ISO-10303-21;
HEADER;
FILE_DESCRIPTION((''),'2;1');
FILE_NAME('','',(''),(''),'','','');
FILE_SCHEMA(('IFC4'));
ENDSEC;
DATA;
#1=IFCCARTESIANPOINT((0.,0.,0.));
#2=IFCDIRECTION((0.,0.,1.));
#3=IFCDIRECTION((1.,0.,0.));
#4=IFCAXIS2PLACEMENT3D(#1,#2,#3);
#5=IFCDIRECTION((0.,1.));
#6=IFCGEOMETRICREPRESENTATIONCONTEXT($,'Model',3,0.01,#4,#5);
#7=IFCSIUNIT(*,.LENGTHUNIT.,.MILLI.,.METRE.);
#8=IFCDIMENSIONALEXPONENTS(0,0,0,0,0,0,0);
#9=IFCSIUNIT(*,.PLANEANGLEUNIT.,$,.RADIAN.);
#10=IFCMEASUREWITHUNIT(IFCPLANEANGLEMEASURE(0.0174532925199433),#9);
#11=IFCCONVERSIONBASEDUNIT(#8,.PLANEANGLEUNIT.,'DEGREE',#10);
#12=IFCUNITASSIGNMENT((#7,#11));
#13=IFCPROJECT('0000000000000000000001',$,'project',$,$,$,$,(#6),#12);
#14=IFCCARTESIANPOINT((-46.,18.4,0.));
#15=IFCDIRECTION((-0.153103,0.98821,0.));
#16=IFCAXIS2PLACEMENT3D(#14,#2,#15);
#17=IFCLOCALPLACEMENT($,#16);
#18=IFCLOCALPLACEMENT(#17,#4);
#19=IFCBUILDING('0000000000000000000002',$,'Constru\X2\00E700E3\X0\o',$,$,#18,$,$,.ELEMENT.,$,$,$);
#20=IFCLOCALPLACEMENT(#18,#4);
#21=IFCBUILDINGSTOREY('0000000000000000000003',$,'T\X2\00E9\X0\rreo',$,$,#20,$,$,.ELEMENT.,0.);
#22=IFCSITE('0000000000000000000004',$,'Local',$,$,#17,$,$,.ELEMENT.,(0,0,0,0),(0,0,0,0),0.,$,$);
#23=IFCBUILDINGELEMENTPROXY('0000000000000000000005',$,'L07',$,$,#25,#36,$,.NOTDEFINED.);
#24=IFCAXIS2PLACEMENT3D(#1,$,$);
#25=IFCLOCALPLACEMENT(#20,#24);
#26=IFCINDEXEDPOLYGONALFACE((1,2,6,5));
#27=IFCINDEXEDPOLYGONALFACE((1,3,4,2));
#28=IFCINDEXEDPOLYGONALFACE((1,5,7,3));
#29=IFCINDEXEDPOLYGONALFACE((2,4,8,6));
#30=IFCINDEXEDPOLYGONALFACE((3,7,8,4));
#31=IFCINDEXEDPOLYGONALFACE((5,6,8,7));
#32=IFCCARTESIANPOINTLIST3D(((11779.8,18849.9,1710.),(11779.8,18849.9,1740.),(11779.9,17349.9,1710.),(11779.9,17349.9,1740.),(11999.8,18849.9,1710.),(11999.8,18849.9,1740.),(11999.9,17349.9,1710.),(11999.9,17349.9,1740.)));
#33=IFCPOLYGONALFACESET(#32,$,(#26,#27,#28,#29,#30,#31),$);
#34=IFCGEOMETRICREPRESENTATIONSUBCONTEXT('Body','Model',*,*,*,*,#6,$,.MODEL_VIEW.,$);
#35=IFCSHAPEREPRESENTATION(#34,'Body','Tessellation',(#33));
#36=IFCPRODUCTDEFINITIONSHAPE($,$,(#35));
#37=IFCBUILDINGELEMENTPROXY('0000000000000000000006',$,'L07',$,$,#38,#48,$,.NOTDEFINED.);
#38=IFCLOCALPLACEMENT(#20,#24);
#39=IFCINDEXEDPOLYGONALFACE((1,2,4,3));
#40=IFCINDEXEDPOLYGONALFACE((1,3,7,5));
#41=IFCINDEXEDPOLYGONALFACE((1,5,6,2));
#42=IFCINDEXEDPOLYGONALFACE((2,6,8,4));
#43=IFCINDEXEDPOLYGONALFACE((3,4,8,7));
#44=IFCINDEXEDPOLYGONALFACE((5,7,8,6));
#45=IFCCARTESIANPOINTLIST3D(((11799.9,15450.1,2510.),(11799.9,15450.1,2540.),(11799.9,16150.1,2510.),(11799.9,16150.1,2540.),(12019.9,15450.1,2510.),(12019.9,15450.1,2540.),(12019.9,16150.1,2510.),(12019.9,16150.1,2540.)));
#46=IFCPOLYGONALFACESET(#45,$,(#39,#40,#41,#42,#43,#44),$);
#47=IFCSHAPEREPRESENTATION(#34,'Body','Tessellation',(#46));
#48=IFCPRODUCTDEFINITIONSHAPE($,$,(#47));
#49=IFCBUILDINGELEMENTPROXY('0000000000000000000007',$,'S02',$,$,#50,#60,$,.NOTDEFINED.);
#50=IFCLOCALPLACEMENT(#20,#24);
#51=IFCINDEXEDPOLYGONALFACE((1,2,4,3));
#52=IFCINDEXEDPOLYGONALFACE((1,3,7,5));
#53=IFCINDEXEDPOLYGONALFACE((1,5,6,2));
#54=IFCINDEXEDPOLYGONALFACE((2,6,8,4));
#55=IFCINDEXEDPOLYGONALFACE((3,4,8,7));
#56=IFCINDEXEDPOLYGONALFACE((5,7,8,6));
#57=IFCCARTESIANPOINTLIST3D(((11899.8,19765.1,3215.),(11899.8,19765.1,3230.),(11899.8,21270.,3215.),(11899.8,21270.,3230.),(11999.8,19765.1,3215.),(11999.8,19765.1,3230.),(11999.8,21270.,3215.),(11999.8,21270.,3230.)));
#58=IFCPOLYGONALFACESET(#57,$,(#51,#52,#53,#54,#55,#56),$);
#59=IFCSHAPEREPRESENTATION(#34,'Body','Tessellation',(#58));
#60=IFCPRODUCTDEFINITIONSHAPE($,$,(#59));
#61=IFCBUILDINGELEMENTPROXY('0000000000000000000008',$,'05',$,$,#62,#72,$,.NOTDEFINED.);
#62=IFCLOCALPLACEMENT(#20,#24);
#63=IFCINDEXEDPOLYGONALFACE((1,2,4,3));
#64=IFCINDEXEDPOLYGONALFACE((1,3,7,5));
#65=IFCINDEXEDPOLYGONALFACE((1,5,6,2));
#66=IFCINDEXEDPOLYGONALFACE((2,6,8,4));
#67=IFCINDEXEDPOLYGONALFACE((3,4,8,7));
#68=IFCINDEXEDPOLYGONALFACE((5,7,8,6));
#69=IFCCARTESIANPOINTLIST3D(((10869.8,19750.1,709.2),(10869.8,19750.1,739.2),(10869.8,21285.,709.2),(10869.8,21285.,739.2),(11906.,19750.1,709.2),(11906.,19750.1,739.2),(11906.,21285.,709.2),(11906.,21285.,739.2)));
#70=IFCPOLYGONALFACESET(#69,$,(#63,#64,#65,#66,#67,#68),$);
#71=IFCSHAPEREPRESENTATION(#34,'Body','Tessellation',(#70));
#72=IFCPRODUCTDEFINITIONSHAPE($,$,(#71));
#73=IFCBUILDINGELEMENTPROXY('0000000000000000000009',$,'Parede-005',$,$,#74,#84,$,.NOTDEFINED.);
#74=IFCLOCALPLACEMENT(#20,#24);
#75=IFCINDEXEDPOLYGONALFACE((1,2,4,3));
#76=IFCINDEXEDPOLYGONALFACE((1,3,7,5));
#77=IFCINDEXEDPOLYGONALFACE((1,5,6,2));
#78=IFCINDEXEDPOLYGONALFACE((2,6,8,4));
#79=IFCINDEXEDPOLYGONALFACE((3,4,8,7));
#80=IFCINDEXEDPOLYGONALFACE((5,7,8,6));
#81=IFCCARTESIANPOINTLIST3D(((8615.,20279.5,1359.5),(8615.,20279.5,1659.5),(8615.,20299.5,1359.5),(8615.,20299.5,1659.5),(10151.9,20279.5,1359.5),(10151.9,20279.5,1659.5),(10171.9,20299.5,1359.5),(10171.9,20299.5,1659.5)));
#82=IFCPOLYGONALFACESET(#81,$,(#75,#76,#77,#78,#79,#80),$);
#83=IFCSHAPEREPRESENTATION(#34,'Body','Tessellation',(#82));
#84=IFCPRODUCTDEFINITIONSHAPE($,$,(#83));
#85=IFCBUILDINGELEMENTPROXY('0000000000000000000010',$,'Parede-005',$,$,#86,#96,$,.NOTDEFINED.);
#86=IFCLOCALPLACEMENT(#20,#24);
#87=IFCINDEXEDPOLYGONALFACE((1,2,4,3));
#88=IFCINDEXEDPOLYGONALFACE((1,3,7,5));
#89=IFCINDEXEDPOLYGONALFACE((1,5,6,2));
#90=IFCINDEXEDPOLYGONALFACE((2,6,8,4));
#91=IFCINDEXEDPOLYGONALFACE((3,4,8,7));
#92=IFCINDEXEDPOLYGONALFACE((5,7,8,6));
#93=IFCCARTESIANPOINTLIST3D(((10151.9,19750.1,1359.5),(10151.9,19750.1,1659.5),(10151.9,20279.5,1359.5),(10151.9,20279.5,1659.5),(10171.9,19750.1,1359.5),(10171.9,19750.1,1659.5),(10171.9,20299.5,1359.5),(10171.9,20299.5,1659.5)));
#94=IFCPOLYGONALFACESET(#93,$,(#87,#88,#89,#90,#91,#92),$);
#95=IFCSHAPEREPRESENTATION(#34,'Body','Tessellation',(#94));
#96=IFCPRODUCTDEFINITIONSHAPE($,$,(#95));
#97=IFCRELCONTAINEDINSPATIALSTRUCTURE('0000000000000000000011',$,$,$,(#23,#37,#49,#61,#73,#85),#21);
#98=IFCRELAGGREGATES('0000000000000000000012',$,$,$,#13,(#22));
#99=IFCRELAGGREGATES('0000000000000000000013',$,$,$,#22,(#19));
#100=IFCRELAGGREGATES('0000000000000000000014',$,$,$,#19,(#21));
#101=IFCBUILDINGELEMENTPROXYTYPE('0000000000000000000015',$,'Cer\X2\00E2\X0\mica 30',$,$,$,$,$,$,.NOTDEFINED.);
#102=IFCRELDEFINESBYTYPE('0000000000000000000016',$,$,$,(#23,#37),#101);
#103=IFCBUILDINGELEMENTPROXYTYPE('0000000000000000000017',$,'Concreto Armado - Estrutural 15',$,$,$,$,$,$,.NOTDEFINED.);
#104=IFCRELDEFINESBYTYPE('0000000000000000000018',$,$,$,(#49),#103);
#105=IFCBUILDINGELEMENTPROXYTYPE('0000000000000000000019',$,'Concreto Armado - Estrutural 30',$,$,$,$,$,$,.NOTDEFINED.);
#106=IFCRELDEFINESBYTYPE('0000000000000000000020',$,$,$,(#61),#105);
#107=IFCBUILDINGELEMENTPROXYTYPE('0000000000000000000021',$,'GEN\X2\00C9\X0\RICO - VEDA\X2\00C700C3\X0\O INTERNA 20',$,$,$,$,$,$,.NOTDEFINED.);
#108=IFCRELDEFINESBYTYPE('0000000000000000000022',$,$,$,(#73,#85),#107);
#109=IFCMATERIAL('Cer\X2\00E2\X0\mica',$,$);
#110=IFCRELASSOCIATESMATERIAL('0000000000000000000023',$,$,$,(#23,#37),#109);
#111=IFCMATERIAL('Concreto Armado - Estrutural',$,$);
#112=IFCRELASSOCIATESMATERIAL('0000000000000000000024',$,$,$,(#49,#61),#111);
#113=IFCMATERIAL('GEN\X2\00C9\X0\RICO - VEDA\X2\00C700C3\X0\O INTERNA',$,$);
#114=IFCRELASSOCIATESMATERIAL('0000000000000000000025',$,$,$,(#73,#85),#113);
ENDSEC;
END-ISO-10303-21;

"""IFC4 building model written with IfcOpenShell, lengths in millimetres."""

from ifc_helpers import new_model, entity, si_unit, converted_unit, direction, frame, origin_with_axes, place, context, subcontext, project, spatial, line, indexed_curve, outline, extrude, material, type_object, element, save


model = new_model("IFC4")

# Units and contexts
model_context = context("Model", 3, precision=0.01, world=origin_with_axes(), true_north=direction((0.0, 1.0)))
body_context = subcontext(model_context, "Body", "Model", "MODEL_VIEW")
ifc_project = project(units=[si_unit("LENGTHUNIT", "METRE", prefix="MILLI"), converted_unit("PLANEANGLEUNIT", "DEGREE", entity("IfcPlaneAngleMeasure", 0.0174532925199433), si_unit("PLANEANGLEUNIT", "RADIAN"), dimensions=[0, 0, 0, 0, 0, 0, 0])], contexts=[model_context])

# Site, building, storey
site_placement = place(None, frame((-46.0, 18.4, 0.0), z_axis=(0.0, 0.0, 1.0), x_axis=(-0.153103, 0.98821, 0.0)))
site = spatial("IfcSite", under=ifc_project, at=site_placement, Name="Local", CompositionType="ELEMENT", RefLatitude=(0, 0, 0, 0), RefLongitude=(0, 0, 0, 0), RefElevation=0.0)
building_placement = place(site_placement, origin_with_axes())
building = spatial("IfcBuilding", under=site, at=building_placement, Name="Construção", CompositionType="ELEMENT")
storey_placement = place(building_placement, origin_with_axes())
storey = spatial("IfcBuildingStorey", under=building, at=storey_placement, Name="Térreo", CompositionType="ELEMENT", Elevation=0.0)

# Shared definitions
ifc_material_1 = material(Name="Concreto Armado - Estrutural")

# Shared definitions
ifc_material_2 = material(Name="GENÉRICO - VEDAÇÃO INTERNA")

# Building element proxies
ifc_material_3 = material(Name="Cerâmica")
building_element_proxy_type_1 = type_object("IfcBuildingElementProxyType", Name="Cerâmica 30", PredefinedType="NOTDEFINED")
proxy_1_placement = place(storey_placement, frame((11779.9, 17349.9, 1740.0), z_axis=(0.0, 0.0, 1.0), x_axis=(1.0, 0.0, 0.0)))
element("IfcBuildingElementProxy", 1, at=proxy_1_placement, inside=storey, type_object=building_element_proxy_type_1, material=ifc_material_3, Name="L07", PredefinedType="NOTDEFINED", context=body_context, shape_type="SweptSolid", body=[
    extrude(outline(indexed_curve([(0.0, 0.0), (220.0, 0.0), (220.0, 1500.0), (0.0, 1500.0)], segments=[line(1, 2, 3, 4, 1)])), frame((0.0, 0.0, -30.0), z_axis=(0.0, 0.0, 1.0), x_axis=(1.0, 0.0, 0.0)), (0.0, 0.0, 1.0), 30.0),
])
proxy_2_placement = place(storey_placement, frame((11799.9, 15450.1, 2540.0), z_axis=(0.0, 0.0, 1.0), x_axis=(1.0, 0.0, 0.0)))
element("IfcBuildingElementProxy", 2, at=proxy_2_placement, inside=storey, type_object=building_element_proxy_type_1, material=ifc_material_3, Name="L07", PredefinedType="NOTDEFINED", context=body_context, shape_type="SweptSolid", body=[
    extrude(outline(indexed_curve([(0.0, 0.0), (220.0, 0.0), (220.0, 700.0), (0.0, 700.0)], segments=[line(1, 2, 3, 4, 1)])), frame((0.0, 0.0, -30.0), z_axis=(0.0, 0.0, 1.0), x_axis=(1.0, 0.0, 0.0)), (0.0, 0.0, 1.0), 30.0),
])
building_element_proxy_type_2 = type_object("IfcBuildingElementProxyType", Name="Concreto Armado - Estrutural 15", PredefinedType="NOTDEFINED")
proxy_3_placement = place(storey_placement, frame((11899.8, 19765.1, 3230.0), z_axis=(0.0, 0.0, 1.0), x_axis=(1.0, 0.0, 0.0)))
element("IfcBuildingElementProxy", 3, at=proxy_3_placement, inside=storey, type_object=building_element_proxy_type_2, material=ifc_material_1, Name="S02", PredefinedType="NOTDEFINED", context=body_context, shape_type="SweptSolid", body=[
    extrude(outline(indexed_curve([(0.0, 0.0), (100.0, 0.0), (100.0, 1505.0), (0.0, 1505.0)], segments=[line(1, 2, 3, 4, 1)])), frame((0.0, 0.0, -15.0), z_axis=(0.0, 0.0, 1.0), x_axis=(1.0, 0.0, 0.0)), (0.0, 0.0, 1.0), 15.0),
])
building_element_proxy_type_3 = type_object("IfcBuildingElementProxyType", Name="Concreto Armado - Estrutural 30", PredefinedType="NOTDEFINED")
proxy_4_placement = place(storey_placement, frame((10869.8, 19750.1, 739.2), z_axis=(0.0, 0.0, 1.0), x_axis=(1.0, 0.0, 0.0)))
element("IfcBuildingElementProxy", 4, at=proxy_4_placement, inside=storey, type_object=building_element_proxy_type_3, material=ifc_material_1, Name="05", PredefinedType="NOTDEFINED", context=body_context, shape_type="SweptSolid", body=[
    extrude(outline(indexed_curve([(0.0, 0.0), (1036.2, 0.0), (1036.2, 1535.0), (0.0, 1535.0)], segments=[line(1, 2, 3, 4, 1)])), frame((0.0, 0.0, -30.0), z_axis=(0.0, 0.0, 1.0), x_axis=(1.0, 0.0, 0.0)), (0.0, 0.0, 1.0), 30.0),
])
building_element_proxy_type_4 = type_object("IfcBuildingElementProxyType", Name="GENÉRICO - VEDAÇÃO INTERNA 20", PredefinedType="NOTDEFINED")
proxy_5_placement = place(storey_placement, frame((10171.9, 20299.5, 1359.5), z_axis=(0.0, 0.0, 1.0), x_axis=(-1.0, 0.0, 0.0)))
element("IfcBuildingElementProxy", 5, at=proxy_5_placement, inside=storey, type_object=building_element_proxy_type_4, material=ifc_material_2, Name="Parede-005", PredefinedType="NOTDEFINED", context=body_context, shape_type="SweptSolid", body=[
    extrude(outline(indexed_curve([(0.0, 0.0), (1557.0, 0.0), (1557.0, 20.0), (20.0, 20.0)], segments=[line(1, 2, 3, 4, 1)])), origin_with_axes(), (0.0, 0.0, 1.0), 300.0),
])
proxy_6_placement = place(storey_placement, frame((10171.9, 19750.1, 1359.5), z_axis=(0.0, 0.0, 1.0), x_axis=(0.0, 1.0, 0.0)))
element("IfcBuildingElementProxy", 6, at=proxy_6_placement, inside=storey, type_object=building_element_proxy_type_4, material=ifc_material_2, Name="Parede-005", PredefinedType="NOTDEFINED", context=body_context, shape_type="SweptSolid", body=[
    extrude(outline(indexed_curve([(0.0, 0.0), (549.5, 0.0), (529.5, 20.0), (0.0, 20.0)], segments=[line(1, 2, 3, 4, 1)])), origin_with_axes(), (0.0, 0.0, 1.0), 300.0),
])

save(model, "model.ifc")
